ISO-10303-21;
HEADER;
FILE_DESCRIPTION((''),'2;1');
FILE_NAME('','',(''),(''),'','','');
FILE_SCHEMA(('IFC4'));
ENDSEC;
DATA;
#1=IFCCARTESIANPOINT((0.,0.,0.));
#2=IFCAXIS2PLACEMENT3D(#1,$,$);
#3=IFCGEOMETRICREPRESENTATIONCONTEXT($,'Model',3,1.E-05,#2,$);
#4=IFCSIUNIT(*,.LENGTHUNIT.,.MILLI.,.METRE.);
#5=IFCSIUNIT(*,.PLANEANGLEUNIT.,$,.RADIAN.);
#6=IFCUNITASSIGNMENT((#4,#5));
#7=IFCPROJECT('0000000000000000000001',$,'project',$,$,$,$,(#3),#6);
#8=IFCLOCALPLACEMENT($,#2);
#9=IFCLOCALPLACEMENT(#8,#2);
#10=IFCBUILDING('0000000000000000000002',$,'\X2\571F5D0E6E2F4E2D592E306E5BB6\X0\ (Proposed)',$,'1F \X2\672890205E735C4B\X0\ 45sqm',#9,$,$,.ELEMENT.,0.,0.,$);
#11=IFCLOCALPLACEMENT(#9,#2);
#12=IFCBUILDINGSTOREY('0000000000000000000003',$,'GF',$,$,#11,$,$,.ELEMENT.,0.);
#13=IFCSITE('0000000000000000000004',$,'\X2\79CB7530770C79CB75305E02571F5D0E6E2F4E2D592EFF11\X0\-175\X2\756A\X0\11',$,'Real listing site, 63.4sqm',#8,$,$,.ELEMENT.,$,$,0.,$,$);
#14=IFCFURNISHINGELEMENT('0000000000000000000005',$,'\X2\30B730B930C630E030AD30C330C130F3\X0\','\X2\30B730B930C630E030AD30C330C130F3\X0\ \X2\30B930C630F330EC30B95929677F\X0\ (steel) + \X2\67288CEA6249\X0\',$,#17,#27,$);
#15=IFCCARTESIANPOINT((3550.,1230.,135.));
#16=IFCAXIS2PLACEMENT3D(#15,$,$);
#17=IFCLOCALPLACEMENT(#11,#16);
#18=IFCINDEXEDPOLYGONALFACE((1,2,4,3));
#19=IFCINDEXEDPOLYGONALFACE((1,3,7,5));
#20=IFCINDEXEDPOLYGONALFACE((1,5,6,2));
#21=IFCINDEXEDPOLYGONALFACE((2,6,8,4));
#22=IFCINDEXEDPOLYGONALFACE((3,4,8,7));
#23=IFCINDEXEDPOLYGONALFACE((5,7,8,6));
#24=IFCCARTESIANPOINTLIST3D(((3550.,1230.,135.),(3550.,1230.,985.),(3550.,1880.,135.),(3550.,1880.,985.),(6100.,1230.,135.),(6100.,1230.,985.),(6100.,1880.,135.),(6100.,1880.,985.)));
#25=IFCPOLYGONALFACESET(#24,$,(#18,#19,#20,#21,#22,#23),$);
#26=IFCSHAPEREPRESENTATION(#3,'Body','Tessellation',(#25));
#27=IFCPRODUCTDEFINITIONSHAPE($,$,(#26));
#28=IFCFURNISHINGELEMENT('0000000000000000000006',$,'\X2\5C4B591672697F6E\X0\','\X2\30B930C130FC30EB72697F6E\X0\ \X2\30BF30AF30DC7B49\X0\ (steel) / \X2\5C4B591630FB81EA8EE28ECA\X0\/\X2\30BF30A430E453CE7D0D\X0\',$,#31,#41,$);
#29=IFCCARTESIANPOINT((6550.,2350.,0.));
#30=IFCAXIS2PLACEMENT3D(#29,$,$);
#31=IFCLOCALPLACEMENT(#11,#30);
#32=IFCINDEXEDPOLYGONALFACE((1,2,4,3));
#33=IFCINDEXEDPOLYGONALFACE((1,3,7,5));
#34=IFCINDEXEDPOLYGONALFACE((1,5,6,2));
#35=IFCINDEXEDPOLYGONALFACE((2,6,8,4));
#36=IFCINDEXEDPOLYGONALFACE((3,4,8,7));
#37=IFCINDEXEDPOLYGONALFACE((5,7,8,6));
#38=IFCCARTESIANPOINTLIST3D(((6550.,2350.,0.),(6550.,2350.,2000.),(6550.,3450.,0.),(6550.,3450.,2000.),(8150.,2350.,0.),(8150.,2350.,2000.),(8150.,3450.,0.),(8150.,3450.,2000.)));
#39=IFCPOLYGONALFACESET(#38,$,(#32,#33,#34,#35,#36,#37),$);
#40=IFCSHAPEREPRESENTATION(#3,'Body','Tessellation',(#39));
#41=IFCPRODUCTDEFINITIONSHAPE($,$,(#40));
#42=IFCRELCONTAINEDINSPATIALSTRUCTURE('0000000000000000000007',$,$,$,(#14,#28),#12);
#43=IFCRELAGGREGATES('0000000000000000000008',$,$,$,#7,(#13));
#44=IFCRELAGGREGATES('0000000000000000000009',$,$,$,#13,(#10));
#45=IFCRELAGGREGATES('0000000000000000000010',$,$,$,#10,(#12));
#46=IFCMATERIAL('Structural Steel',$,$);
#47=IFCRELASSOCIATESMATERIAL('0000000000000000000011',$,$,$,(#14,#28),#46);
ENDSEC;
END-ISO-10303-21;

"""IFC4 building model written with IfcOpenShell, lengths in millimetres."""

from ifc_helpers import new_model, si_unit, frame, frame_2d, origin, place, context, project, spatial, rectangle, extrude, material, element, save


model = new_model("IFC4")

# Units and contexts
model_context = context("Model", 3, precision=1e-05, world=origin())
ifc_project = project(units=[si_unit("LENGTHUNIT", "METRE", prefix="MILLI"), si_unit("PLANEANGLEUNIT", "RADIAN")], contexts=[model_context])

# Site, building, storey
site_placement = place(None, origin())
site = spatial("IfcSite", under=ifc_project, at=site_placement, Name="秋田県秋田市土崎港中央１-175番11", ObjectType="Real listing site, 63.4sqm", CompositionType="ELEMENT", RefElevation=0.0)
building_placement = place(site_placement, origin())
building = spatial("IfcBuilding", under=site, at=building_placement, Name="土崎港中央の家 (Proposed)", ObjectType="1F 木造平屋 45sqm", CompositionType="ELEMENT", ElevationOfRefHeight=0.0, ElevationOfTerrain=0.0)
storey_placement = place(building_placement, origin())
storey = spatial("IfcBuildingStorey", under=building, at=storey_placement, Name="GF", CompositionType="ELEMENT", Elevation=0.0)

# Shared definitions
ifc_material_1 = material(Name="Structural Steel")

# Furnishing elements
furnishing_1_placement = place(storey_placement, frame((3550.0, 1230.0, 135.0)))
element("IfcFurnishingElement", 1, at=furnishing_1_placement, inside=storey, material=ifc_material_1, Name="システムキッチン", Description="システムキッチン ステンレス天板 (steel) + 木質扉", context=model_context, shape_type="SweptSolid", body=[
    extrude(rectangle(XDim=2550.0, YDim=650.0, at=frame_2d((1275.0, 325.0))), frame((3550.0, 1230.0, 135.0)), (0.0, 0.0, 1.0), 850.0),
])
furnishing_2_placement = place(storey_placement, frame((6550.0, 2350.0, 0.0)))
element("IfcFurnishingElement", 2, at=furnishing_2_placement, inside=storey, material=ifc_material_1, Name="屋外物置", Description="スチール物置 タクボ等 (steel) / 屋外・自転車/タイヤ収納", context=model_context, shape_type="SweptSolid", body=[
    extrude(rectangle(XDim=1600.0, YDim=1100.0, at=frame_2d((800.0, 550.0))), frame((6550.0, 2350.0, 0.0)), (0.0, 0.0, 1.0), 2000.0),
])

save(model, "model.ifc")
